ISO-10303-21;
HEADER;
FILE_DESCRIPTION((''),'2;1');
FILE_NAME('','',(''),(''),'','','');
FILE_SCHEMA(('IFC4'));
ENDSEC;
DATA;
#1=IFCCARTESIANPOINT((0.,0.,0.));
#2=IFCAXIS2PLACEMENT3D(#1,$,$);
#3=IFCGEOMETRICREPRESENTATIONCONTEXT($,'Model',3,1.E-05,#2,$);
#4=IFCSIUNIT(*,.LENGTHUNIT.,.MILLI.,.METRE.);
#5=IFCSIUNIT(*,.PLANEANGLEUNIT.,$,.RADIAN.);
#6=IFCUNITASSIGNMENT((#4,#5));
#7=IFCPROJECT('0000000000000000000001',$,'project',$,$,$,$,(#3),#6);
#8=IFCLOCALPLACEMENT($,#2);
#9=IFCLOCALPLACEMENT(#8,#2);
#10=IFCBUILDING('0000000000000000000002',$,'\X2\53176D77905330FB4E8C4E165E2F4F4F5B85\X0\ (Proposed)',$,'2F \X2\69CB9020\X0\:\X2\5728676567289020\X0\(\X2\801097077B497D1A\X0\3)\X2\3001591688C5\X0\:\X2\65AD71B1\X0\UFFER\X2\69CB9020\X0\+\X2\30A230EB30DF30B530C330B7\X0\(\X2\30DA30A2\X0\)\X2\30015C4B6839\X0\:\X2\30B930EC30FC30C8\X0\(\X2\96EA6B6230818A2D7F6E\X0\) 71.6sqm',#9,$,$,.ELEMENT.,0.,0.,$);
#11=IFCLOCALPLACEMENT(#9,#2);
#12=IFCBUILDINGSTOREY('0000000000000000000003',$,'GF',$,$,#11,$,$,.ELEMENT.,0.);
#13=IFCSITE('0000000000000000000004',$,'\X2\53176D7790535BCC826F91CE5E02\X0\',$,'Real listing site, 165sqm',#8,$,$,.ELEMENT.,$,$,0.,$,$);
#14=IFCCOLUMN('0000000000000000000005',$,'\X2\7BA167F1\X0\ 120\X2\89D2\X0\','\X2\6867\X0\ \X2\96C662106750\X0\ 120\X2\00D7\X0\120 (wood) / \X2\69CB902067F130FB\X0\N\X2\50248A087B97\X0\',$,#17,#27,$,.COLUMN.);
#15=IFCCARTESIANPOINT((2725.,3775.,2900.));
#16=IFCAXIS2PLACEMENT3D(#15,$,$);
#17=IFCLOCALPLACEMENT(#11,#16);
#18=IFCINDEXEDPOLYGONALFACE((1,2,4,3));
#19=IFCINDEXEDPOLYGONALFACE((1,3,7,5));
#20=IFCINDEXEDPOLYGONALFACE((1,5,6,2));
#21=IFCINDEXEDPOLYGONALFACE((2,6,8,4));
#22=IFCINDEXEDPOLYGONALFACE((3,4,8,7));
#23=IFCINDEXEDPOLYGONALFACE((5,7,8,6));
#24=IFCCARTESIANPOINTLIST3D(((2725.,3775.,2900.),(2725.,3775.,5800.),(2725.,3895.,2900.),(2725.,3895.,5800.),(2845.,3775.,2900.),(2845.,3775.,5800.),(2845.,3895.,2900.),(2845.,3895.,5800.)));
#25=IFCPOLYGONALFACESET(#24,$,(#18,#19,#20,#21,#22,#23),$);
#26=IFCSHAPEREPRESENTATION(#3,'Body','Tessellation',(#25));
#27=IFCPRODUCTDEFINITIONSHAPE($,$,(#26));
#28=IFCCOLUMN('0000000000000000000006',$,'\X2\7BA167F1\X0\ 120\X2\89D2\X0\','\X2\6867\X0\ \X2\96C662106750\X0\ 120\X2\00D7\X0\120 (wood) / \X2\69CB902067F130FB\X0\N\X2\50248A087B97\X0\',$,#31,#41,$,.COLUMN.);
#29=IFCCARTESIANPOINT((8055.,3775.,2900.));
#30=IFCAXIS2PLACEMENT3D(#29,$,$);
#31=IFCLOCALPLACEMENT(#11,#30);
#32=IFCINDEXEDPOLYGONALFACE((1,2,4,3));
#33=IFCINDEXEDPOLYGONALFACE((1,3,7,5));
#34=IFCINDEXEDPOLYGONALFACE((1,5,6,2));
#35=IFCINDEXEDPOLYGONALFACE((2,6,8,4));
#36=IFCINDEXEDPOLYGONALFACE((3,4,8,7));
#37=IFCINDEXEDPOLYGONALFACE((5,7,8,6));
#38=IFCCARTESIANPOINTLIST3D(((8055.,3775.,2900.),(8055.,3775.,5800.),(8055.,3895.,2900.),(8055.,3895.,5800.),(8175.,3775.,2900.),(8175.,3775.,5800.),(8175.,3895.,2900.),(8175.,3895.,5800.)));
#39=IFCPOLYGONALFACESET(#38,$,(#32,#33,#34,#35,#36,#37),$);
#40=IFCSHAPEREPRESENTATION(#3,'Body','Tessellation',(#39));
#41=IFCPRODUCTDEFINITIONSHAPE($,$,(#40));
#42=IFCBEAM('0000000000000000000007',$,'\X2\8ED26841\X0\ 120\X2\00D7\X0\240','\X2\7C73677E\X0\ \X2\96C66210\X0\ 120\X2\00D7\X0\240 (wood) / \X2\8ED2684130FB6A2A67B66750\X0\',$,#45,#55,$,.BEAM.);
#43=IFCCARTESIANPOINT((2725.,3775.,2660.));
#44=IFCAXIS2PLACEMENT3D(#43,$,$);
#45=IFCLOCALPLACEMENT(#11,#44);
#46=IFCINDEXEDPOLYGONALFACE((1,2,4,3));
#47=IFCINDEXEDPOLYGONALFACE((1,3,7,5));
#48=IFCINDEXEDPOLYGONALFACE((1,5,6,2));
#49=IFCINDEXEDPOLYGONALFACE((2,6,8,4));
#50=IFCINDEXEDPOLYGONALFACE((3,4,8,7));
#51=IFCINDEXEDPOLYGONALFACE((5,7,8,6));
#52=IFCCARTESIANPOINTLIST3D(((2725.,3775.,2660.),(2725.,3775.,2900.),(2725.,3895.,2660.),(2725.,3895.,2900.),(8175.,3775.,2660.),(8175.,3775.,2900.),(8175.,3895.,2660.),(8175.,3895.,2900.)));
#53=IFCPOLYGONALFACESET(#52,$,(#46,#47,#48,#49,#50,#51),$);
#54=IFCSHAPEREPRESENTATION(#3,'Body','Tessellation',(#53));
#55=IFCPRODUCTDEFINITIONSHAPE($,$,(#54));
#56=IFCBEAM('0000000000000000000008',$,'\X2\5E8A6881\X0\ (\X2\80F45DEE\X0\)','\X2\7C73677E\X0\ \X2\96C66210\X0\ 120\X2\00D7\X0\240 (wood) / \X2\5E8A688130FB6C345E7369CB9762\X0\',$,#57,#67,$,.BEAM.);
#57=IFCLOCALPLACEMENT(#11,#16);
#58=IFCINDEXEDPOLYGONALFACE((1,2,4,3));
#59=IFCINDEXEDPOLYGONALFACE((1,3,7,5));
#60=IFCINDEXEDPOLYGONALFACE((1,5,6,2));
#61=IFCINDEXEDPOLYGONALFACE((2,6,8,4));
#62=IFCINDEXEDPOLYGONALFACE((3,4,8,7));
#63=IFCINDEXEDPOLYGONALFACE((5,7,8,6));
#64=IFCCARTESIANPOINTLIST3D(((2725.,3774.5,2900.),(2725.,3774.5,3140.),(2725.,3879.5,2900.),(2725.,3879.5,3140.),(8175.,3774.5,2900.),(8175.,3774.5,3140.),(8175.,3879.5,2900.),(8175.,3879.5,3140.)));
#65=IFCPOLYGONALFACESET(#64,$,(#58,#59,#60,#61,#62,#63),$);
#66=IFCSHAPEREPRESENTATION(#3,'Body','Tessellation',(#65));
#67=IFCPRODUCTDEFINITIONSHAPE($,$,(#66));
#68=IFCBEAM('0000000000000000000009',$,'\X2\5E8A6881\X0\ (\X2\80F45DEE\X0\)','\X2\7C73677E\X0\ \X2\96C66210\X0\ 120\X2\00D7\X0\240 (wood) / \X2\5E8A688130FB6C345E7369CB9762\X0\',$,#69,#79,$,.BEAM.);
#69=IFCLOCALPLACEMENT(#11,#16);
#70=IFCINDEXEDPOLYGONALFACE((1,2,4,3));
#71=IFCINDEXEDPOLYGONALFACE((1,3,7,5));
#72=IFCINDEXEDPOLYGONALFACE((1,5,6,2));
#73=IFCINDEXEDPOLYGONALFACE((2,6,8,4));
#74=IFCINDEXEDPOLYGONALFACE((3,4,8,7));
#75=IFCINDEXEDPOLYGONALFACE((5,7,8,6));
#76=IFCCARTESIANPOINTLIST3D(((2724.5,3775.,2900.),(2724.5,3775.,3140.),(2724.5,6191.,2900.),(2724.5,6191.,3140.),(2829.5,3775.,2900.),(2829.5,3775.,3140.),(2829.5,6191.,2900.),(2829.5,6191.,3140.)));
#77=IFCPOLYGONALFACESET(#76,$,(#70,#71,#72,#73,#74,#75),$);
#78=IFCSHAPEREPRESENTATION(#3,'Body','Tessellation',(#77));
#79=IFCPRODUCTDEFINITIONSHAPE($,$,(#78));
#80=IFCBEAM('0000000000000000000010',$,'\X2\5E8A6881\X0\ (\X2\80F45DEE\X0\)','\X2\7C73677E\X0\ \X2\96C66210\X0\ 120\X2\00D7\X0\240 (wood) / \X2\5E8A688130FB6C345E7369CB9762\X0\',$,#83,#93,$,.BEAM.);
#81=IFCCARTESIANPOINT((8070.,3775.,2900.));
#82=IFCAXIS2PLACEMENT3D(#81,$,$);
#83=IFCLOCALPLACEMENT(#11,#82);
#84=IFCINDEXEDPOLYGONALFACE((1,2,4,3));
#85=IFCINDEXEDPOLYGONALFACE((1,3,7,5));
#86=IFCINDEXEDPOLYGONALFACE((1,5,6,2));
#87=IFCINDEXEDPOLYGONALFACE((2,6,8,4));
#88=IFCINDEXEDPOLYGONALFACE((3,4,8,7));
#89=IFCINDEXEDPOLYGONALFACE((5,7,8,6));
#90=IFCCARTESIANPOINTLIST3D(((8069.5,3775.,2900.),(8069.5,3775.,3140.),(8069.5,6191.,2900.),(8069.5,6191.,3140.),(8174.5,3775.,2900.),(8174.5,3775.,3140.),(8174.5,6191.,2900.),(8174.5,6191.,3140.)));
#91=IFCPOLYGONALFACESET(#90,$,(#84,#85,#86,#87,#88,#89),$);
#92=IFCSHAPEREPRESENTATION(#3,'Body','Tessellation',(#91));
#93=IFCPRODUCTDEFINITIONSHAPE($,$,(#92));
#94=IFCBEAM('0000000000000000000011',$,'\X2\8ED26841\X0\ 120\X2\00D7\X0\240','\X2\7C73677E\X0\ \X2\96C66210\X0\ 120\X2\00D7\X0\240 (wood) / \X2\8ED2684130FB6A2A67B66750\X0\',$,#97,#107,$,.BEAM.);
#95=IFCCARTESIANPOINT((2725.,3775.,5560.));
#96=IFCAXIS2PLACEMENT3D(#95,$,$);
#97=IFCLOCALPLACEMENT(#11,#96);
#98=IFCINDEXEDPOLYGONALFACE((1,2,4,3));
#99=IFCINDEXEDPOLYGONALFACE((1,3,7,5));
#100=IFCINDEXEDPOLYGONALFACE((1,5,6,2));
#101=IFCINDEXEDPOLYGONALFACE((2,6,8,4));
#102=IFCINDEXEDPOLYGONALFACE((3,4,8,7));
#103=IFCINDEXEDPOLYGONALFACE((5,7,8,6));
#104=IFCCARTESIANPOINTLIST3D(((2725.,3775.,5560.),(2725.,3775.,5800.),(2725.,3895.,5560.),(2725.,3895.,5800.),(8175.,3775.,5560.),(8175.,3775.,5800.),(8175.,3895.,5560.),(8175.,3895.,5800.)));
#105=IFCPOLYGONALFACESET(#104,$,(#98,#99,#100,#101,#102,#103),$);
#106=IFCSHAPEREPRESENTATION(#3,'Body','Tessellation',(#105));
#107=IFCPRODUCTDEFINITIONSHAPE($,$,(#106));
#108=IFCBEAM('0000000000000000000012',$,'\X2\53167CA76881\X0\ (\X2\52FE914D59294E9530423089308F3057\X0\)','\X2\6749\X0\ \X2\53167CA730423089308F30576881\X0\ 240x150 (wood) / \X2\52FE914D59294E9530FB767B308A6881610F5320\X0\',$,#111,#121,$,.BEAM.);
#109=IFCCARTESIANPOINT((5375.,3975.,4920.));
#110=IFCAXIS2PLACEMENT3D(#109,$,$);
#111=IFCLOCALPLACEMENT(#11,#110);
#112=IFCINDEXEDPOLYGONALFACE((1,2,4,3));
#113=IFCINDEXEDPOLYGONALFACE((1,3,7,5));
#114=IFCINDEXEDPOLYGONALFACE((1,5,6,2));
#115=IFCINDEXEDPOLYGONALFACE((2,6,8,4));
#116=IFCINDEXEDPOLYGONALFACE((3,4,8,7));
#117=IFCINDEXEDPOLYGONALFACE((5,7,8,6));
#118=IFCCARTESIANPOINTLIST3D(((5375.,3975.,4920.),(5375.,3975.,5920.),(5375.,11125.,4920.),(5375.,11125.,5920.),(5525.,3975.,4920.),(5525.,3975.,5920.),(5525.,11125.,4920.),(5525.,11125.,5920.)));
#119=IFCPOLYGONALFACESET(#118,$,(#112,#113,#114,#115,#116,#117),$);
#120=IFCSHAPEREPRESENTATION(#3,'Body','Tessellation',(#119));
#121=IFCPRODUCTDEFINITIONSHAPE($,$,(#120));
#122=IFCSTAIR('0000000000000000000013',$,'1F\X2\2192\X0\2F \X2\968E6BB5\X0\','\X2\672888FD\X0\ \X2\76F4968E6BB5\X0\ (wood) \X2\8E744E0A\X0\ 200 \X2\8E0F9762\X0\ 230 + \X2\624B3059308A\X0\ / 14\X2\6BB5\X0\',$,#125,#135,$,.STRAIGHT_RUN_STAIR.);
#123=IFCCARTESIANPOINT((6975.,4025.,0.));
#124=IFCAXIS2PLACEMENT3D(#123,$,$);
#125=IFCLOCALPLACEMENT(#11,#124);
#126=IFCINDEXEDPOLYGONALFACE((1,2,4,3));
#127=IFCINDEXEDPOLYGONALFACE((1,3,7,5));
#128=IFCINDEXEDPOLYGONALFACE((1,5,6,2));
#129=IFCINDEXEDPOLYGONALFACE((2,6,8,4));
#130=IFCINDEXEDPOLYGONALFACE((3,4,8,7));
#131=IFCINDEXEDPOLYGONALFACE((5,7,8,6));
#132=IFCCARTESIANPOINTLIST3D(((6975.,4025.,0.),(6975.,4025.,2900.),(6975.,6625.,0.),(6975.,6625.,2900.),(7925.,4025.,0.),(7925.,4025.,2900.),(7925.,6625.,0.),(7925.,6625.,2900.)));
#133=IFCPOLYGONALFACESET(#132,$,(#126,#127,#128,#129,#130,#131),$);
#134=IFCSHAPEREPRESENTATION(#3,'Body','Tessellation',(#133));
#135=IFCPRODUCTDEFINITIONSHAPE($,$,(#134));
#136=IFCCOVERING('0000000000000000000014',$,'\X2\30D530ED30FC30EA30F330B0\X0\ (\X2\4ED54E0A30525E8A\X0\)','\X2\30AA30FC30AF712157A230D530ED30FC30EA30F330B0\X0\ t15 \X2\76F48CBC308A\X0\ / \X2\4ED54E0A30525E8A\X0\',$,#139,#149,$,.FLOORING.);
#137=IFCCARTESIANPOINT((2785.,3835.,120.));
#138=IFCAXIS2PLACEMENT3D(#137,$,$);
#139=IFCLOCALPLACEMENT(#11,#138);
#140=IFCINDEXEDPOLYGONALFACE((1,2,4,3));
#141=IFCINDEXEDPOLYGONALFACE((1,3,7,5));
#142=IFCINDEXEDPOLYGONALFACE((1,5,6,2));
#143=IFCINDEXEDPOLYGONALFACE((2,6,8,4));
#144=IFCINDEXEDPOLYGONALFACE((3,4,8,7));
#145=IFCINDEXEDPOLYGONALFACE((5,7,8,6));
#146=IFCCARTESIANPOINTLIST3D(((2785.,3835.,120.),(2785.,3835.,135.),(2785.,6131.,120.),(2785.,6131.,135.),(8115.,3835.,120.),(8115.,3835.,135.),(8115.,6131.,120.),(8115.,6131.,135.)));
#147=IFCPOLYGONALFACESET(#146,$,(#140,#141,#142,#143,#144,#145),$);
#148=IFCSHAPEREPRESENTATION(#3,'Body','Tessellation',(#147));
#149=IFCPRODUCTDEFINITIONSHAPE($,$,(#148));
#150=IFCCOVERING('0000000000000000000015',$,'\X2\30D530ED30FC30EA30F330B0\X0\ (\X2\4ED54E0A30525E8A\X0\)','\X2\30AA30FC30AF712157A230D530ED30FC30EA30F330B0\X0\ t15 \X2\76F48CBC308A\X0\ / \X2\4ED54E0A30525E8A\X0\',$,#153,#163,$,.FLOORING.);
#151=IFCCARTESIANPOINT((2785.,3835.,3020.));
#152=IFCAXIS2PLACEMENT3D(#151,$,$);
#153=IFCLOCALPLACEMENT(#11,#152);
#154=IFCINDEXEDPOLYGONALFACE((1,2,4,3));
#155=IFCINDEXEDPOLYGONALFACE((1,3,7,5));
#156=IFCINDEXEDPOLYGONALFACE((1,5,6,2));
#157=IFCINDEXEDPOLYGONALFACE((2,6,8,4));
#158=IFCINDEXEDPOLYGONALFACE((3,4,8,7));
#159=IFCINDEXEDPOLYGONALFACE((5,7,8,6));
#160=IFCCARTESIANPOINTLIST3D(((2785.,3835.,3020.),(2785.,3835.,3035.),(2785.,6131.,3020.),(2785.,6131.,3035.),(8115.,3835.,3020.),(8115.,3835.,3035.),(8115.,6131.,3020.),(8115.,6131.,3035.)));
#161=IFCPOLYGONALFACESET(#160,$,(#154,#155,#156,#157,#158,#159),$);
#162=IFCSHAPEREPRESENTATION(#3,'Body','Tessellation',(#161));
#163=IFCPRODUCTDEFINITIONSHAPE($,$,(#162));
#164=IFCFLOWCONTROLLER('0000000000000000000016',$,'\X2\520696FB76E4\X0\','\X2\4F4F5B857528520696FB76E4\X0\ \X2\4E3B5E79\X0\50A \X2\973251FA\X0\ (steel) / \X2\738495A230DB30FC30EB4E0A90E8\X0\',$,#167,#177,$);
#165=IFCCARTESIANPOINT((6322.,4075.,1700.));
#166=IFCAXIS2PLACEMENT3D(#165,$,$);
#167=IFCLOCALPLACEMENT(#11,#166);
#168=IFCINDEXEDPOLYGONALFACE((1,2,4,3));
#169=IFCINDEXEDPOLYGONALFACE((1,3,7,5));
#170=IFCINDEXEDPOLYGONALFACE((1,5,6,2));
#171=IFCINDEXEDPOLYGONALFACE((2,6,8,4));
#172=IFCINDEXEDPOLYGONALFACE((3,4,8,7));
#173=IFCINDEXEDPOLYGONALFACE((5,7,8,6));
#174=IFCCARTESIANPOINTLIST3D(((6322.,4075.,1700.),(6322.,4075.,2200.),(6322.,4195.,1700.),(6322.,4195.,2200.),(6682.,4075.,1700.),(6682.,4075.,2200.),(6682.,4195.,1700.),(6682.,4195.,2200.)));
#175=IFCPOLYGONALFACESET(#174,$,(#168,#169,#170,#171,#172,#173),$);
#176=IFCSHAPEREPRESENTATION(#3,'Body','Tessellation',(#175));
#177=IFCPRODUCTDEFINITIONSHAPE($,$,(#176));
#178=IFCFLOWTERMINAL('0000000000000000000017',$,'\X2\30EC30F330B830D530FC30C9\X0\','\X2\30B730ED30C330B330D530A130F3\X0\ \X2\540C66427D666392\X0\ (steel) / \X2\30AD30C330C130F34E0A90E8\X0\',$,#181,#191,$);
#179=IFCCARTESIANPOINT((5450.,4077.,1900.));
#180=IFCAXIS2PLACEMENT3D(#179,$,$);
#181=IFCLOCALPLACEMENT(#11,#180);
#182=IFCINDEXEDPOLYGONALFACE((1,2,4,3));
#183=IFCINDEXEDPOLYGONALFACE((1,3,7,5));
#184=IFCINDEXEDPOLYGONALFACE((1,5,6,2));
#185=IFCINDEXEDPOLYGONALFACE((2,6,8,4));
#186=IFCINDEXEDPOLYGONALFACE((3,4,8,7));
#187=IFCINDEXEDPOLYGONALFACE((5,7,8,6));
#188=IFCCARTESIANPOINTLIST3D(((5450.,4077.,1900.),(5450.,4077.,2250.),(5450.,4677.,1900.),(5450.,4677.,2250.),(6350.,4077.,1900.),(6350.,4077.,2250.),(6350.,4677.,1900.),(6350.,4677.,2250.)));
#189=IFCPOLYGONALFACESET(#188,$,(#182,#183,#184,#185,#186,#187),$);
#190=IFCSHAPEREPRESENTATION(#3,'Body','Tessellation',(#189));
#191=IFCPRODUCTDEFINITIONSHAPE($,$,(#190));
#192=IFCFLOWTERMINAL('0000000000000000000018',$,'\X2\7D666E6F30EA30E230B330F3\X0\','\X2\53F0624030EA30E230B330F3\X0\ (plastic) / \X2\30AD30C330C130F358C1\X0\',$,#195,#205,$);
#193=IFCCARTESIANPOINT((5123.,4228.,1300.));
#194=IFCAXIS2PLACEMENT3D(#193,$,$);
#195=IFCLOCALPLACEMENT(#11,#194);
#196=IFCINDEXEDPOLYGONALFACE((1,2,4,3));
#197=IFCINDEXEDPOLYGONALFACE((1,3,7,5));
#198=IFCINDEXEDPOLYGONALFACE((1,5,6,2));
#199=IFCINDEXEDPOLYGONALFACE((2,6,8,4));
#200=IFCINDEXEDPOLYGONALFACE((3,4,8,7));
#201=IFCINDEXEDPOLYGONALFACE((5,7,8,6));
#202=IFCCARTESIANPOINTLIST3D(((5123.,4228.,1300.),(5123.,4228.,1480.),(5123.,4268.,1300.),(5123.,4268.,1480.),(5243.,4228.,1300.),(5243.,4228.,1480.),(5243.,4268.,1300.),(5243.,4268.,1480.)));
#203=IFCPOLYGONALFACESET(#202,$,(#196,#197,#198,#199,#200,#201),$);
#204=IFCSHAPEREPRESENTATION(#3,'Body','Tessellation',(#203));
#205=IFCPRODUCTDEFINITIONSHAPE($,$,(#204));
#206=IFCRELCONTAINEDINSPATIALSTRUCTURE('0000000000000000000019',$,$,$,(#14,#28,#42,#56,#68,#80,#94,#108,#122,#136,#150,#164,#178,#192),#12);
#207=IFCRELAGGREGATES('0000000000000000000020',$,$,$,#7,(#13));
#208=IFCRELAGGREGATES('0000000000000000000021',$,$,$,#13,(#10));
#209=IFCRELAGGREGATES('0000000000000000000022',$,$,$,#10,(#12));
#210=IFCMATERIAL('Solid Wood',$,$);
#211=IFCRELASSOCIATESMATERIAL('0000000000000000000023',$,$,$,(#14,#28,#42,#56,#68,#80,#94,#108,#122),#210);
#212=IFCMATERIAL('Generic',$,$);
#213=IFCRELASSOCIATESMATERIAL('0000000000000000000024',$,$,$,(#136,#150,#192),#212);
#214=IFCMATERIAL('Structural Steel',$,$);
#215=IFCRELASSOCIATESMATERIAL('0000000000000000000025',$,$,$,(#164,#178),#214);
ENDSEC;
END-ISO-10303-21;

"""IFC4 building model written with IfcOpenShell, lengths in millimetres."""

from ifc_helpers import new_model, si_unit, frame, frame_2d, origin, place, context, project, spatial, rectangle, extrude, material, element, save


model = new_model("IFC4")

# Units and contexts
model_context = context("Model", 3, precision=1e-05, world=origin())
ifc_project = project(units=[si_unit("LENGTHUNIT", "METRE", prefix="MILLI"), si_unit("PLANEANGLEUNIT", "RADIAN")], contexts=[model_context])

# Site, building, storey
site_placement = place(None, origin())
site = spatial("IfcSite", under=ifc_project, at=site_placement, Name="北海道富良野市", ObjectType="Real listing site, 165sqm", CompositionType="ELEMENT", RefElevation=0.0)
building_placement = place(site_placement, origin())
building = spatial("IfcBuilding", under=site, at=building_placement, Name="北海道・二世帯住宅 (Proposed)", ObjectType="2F 構造:在来木造(耐震等級3)、外装:断熱UFFER構造+アルミサッシ(ペア)、屋根:スレート(雪止め設置) 71.6sqm", CompositionType="ELEMENT", ElevationOfRefHeight=0.0, ElevationOfTerrain=0.0)
storey_placement = place(building_placement, origin())
storey = spatial("IfcBuildingStorey", under=building, at=storey_placement, Name="GF", CompositionType="ELEMENT", Elevation=0.0)

# Columns
ifc_material_1 = material(Name="Solid Wood")
column_1_placement = place(storey_placement, frame((2725.0, 3775.0, 2900.0)))
element("IfcColumn", 1, at=column_1_placement, inside=storey, material=ifc_material_1, Name="管柱 120角", Description="桧 集成材 120×120 (wood) / 構造柱・N値計算", PredefinedType="COLUMN", context=model_context, shape_type="SweptSolid", body=[
    extrude(rectangle(XDim=120.0, YDim=120.0, at=frame_2d((60.0, 60.0))), frame((2725.0, 3775.0, 2900.0)), (0.0, 0.0, 1.0), 2900.0),
])
column_2_placement = place(storey_placement, frame((8055.0, 3775.0, 2900.0)))
element("IfcColumn", 2, at=column_2_placement, inside=storey, material=ifc_material_1, Name="管柱 120角", Description="桧 集成材 120×120 (wood) / 構造柱・N値計算", PredefinedType="COLUMN", context=model_context, shape_type="SweptSolid", body=[
    extrude(rectangle(XDim=120.0, YDim=120.0, at=frame_2d((60.0, 60.0))), frame((8055.0, 3775.0, 2900.0)), (0.0, 0.0, 1.0), 2900.0),
])

# Beams
beam_1_placement = place(storey_placement, frame((2725.0, 3775.0, 2660.0)))
element("IfcBeam", 3, at=beam_1_placement, inside=storey, material=ifc_material_1, Name="軒桁 120×240", Description="米松 集成 120×240 (wood) / 軒桁・横架材", PredefinedType="BEAM", context=model_context, shape_type="SweptSolid", body=[
    extrude(rectangle(XDim=5450.0, YDim=120.0, at=frame_2d((2725.0, 60.0))), frame((2725.0, 3775.0, 2660.0)), (0.0, 0.0, 1.0), 240.0),
])
beam_2_placement = place(storey_placement, frame((2725.0, 3775.0, 2900.0)))
element("IfcBeam", 4, at=beam_2_placement, inside=storey, material=ifc_material_1, Name="床梁 (胴差)", Description="米松 集成 120×240 (wood) / 床梁・水平構面", PredefinedType="BEAM", context=model_context, shape_type="SweptSolid", body=[
    extrude(rectangle(XDim=5450.0, YDim=105.0, at=frame_2d((2725.0, 52.0))), frame((2725.0, 3775.0, 2900.0)), (0.0, 0.0, 1.0), 240.0),
])
beam_3_placement = place(storey_placement, frame((2725.0, 3775.0, 2900.0)))
element("IfcBeam", 5, at=beam_3_placement, inside=storey, material=ifc_material_1, Name="床梁 (胴差)", Description="米松 集成 120×240 (wood) / 床梁・水平構面", PredefinedType="BEAM", context=model_context, shape_type="SweptSolid", body=[
    extrude(rectangle(XDim=105.0, YDim=2416.0, at=frame_2d((52.0, 1208.0))), frame((2725.0, 3775.0, 2900.0)), (0.0, 0.0, 1.0), 240.0),
])
beam_4_placement = place(storey_placement, frame((8070.0, 3775.0, 2900.0)))
element("IfcBeam", 6, at=beam_4_placement, inside=storey, material=ifc_material_1, Name="床梁 (胴差)", Description="米松 集成 120×240 (wood) / 床梁・水平構面", PredefinedType="BEAM", context=model_context, shape_type="SweptSolid", body=[
    extrude(rectangle(XDim=105.0, YDim=2416.0, at=frame_2d((52.0, 1208.0))), frame((8070.0, 3775.0, 2900.0)), (0.0, 0.0, 1.0), 240.0),
])
beam_5_placement = place(storey_placement, frame((2725.0, 3775.0, 5560.0)))
element("IfcBeam", 7, at=beam_5_placement, inside=storey, material=ifc_material_1, Name="軒桁 120×240", Description="米松 集成 120×240 (wood) / 軒桁・横架材", PredefinedType="BEAM", context=model_context, shape_type="SweptSolid", body=[
    extrude(rectangle(XDim=5450.0, YDim=120.0, at=frame_2d((2725.0, 60.0))), frame((2725.0, 3775.0, 5560.0)), (0.0, 0.0, 1.0), 240.0),
])
beam_6_placement = place(storey_placement, frame((5375.0, 3975.0, 4920.0)))
element("IfcBeam", 8, at=beam_6_placement, inside=storey, material=ifc_material_1, Name="化粧梁 (勾配天井あらわし)", Description="杉 化粧あらわし梁 240x150 (wood) / 勾配天井・登り梁意匠", PredefinedType="BEAM", context=model_context, shape_type="SweptSolid", body=[
    extrude(rectangle(XDim=150.0, YDim=7150.0, at=frame_2d((75.0, 3575.0))), frame((5375.0, 3975.0, 4920.0)), (0.0, 0.0, 1.0), 1000.0),
])

# Stair
stair_placement = place(storey_placement, frame((6975.0, 4025.0, 0.0)))
element("IfcStair", 9, at=stair_placement, inside=storey, material=ifc_material_1, Name="1F→2F 階段", Description="木製 直階段 (wood) 蹴上 200 踏面 230 + 手すり / 14段", PredefinedType="STRAIGHT_RUN_STAIR", context=model_context, shape_type="SweptSolid", body=[
    extrude(rectangle(XDim=950.0, YDim=2600.0, at=frame_2d((475.0, 1300.0))), frame((6975.0, 4025.0, 0.0)), (0.0, 0.0, 1.0), 2900.0),
])

# Coverings
ifc_material_2 = material(Name="Generic")
covering_1_placement = place(storey_placement, frame((2785.0, 3835.0, 120.0)))
element("IfcCovering", 10, at=covering_1_placement, inside=storey, material=ifc_material_2, Name="フローリング (仕上げ床)", Description="オーク無垢フローリング t15 直貼り / 仕上げ床", PredefinedType="FLOORING", context=model_context, shape_type="SweptSolid", body=[
    extrude(rectangle(XDim=5330.0, YDim=2296.0, at=frame_2d((2665.0, 1148.0))), frame((2785.0, 3835.0, 120.0)), (0.0, 0.0, 1.0), 15.0),
])
covering_2_placement = place(storey_placement, frame((2785.0, 3835.0, 3020.0)))
element("IfcCovering", 11, at=covering_2_placement, inside=storey, material=ifc_material_2, Name="フローリング (仕上げ床)", Description="オーク無垢フローリング t15 直貼り / 仕上げ床", PredefinedType="FLOORING", context=model_context, shape_type="SweptSolid", body=[
    extrude(rectangle(XDim=5330.0, YDim=2296.0, at=frame_2d((2665.0, 1148.0))), frame((2785.0, 3835.0, 3020.0)), (0.0, 0.0, 1.0), 15.0),
])

# Flow controller
ifc_material_3 = material(Name="Structural Steel")
flow_controller_placement = place(storey_placement, frame((6322.0, 4075.0, 1700.0)))
element("IfcFlowController", 12, at=flow_controller_placement, inside=storey, material=ifc_material_3, Name="分電盤", Description="住宅用分電盤 主幹50A 露出 (steel) / 玄関ホール上部", context=model_context, shape_type="SweptSolid", body=[
    extrude(rectangle(XDim=360.0, YDim=120.0, at=frame_2d((180.0, 60.0))), frame((6322.0, 4075.0, 1700.0)), (0.0, 0.0, 1.0), 500.0),
])

# Flow terminals
flow_terminal_1_placement = place(storey_placement, frame((5450.0, 4077.0, 1900.0)))
element("IfcFlowTerminal", 13, at=flow_terminal_1_placement, inside=storey, material=ifc_material_3, Name="レンジフード", Description="シロッコファン 同時給排 (steel) / キッチン上部", context=model_context, shape_type="SweptSolid", body=[
    extrude(rectangle(XDim=900.0, YDim=600.0, at=frame_2d((450.0, 300.0))), frame((5450.0, 4077.0, 1900.0)), (0.0, 0.0, 1.0), 350.0),
])
flow_terminal_2_placement = place(storey_placement, frame((5123.0, 4228.0, 1300.0)))
element("IfcFlowTerminal", 14, at=flow_terminal_2_placement, inside=storey, material=ifc_material_2, Name="給湯リモコン", Description="台所リモコン (plastic) / キッチン壁", context=model_context, shape_type="SweptSolid", body=[
    extrude(rectangle(XDim=120.0, YDim=40.0, at=frame_2d((60.0, 20.0))), frame((5123.0, 4228.0, 1300.0)), (0.0, 0.0, 1.0), 180.0),
])

save(model, "model.ifc")
